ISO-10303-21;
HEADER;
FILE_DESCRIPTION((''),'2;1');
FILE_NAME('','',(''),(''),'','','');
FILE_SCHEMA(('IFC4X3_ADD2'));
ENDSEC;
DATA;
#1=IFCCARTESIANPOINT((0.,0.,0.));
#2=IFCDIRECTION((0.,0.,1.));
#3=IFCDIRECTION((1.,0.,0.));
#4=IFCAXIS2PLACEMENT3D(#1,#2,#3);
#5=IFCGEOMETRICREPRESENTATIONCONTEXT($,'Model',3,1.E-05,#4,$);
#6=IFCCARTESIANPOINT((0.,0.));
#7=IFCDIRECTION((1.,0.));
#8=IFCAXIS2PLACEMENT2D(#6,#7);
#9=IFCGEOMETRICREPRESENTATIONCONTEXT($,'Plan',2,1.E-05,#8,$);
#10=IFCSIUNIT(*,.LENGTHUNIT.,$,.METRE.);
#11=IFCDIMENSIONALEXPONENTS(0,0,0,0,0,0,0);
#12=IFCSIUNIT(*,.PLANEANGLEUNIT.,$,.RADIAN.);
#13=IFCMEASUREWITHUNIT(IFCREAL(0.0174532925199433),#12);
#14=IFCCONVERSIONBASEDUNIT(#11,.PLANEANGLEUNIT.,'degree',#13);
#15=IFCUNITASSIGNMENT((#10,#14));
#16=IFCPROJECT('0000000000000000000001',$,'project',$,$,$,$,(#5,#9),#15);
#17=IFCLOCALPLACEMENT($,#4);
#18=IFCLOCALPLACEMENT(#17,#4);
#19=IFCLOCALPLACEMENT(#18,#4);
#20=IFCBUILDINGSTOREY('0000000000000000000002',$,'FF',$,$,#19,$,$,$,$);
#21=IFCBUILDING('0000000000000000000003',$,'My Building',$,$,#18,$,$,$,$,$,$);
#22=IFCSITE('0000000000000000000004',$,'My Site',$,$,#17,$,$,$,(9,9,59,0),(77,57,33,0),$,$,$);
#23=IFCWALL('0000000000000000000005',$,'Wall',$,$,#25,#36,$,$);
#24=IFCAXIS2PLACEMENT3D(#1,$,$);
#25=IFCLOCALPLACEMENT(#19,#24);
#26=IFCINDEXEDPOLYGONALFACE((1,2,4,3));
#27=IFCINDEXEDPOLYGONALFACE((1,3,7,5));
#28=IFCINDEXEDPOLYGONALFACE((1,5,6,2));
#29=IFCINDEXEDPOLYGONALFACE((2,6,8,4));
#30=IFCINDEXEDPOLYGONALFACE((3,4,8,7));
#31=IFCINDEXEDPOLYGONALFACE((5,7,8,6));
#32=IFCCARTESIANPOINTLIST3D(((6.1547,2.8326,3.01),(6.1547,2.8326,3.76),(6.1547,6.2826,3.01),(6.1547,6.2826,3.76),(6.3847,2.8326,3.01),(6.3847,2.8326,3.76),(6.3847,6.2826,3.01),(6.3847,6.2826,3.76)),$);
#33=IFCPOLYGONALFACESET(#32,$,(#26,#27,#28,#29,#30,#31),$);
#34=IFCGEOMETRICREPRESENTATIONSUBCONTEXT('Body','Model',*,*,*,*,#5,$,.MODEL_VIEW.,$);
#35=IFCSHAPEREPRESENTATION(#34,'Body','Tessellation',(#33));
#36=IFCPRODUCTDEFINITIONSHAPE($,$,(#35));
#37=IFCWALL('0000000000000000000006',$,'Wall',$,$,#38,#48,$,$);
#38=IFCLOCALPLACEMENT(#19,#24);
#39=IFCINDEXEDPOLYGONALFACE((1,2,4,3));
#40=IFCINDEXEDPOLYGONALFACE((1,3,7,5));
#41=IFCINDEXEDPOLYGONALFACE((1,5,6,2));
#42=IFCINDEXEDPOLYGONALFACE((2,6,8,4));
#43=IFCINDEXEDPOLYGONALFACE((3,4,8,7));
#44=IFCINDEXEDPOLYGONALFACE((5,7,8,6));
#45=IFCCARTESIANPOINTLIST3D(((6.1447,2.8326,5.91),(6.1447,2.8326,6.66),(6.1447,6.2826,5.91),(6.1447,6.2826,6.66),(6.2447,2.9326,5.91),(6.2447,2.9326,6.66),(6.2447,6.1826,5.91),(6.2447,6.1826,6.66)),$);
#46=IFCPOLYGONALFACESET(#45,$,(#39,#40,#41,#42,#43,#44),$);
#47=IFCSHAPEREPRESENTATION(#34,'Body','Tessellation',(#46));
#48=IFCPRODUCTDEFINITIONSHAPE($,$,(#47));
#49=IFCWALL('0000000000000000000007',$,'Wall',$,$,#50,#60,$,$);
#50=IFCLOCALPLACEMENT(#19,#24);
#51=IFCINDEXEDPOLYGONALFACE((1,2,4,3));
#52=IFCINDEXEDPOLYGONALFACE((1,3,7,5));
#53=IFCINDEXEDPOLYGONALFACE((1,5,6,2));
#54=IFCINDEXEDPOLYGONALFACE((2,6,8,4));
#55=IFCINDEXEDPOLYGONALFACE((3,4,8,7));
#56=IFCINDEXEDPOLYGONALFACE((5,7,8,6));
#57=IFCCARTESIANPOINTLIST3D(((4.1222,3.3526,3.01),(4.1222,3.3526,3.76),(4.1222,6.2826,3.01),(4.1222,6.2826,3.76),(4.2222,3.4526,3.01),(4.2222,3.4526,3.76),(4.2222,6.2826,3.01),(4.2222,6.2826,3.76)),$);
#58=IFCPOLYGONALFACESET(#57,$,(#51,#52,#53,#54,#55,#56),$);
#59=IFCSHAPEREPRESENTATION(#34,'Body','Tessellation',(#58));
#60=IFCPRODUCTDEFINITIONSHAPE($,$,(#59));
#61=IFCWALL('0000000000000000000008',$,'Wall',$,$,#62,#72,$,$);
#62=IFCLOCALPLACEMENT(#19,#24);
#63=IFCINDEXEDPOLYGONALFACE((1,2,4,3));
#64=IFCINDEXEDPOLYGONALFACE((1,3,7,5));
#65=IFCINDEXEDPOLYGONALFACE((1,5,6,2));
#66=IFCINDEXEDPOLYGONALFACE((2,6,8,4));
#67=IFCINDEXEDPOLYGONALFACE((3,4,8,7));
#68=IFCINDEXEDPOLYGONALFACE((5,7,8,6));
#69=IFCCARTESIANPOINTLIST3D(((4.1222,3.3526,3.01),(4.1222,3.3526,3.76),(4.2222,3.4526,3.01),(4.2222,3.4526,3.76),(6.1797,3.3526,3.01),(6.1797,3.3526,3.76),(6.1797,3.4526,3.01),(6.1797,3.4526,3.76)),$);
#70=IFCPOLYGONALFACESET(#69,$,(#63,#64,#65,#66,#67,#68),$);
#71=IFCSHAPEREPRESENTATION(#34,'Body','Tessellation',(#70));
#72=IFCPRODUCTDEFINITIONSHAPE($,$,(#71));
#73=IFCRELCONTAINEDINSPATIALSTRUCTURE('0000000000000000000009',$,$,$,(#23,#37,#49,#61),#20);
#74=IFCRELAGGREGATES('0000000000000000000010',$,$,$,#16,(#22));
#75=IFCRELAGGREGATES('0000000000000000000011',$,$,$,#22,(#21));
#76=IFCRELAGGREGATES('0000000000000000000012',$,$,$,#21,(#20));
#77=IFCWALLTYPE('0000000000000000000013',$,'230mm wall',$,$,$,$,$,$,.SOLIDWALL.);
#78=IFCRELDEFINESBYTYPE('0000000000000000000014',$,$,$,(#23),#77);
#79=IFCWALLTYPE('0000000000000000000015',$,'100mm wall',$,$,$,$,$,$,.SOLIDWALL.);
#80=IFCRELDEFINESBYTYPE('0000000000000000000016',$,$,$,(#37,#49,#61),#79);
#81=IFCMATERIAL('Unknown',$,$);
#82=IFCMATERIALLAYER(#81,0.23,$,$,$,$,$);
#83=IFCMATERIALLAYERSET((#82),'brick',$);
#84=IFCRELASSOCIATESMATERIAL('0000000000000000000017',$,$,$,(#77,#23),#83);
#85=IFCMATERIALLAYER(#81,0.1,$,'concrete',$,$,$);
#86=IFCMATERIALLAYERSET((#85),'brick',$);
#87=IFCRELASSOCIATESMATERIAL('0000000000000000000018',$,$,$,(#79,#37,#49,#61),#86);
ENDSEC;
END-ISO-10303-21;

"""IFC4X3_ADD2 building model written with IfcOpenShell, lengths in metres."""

from ifc_helpers import new_model, entity, si_unit, converted_unit, frame, origin_with_axes, origin_2d_with_axis, place, context, subcontext, project, spatial, line, indexed_curve, outline, extrude, material, layer, layer_set, layer_usage, type_object, element, save


model = new_model("IFC4X3_ADD2")

# Units and contexts
model_context = context("Model", 3, precision=1e-05, world=origin_with_axes())
plan_context = context("Plan", 2, precision=1e-05, world=origin_2d_with_axis())
body_context_1 = subcontext(model_context, "Body", "Model", "MODEL_VIEW")
ifc_project = project(units=[si_unit("LENGTHUNIT", "METRE"), converted_unit("PLANEANGLEUNIT", "degree", entity("IfcReal", 0.0174532925199433), si_unit("PLANEANGLEUNIT", "RADIAN"), dimensions=[0, 0, 0, 0, 0, 0, 0])], contexts=[model_context, plan_context])

# Site, building, storey
site_placement = place(None, origin_with_axes())
site = spatial("IfcSite", under=ifc_project, at=site_placement, Name="My Site", RefLatitude=(9, 9, 59, 0), RefLongitude=(77, 57, 33, 0))
building_placement = place(site_placement, origin_with_axes())
building = spatial("IfcBuilding", under=site, at=building_placement, Name="My Building")
storey_placement = place(building_placement, origin_with_axes())
storey = spatial("IfcBuildingStorey", under=building, at=storey_placement, Name="FF")

# Shared definitions
ifc_material_1 = material(Name="Unknown")

# Shared definitions
ifc_layer_1 = layer(ifc_material_1, 0.23)
ifc_layer_set_1 = layer_set([ifc_layer_1], Name="brick")
wall_type_1 = type_object("IfcWallType", Name="230mm wall", PredefinedType="SOLIDWALL", material=ifc_layer_set_1)

# Walls
ifc_layer_usage_1 = layer_usage(ifc_layer_set_1, "AXIS2", "POSITIVE", 0.0)
wall_1_placement = place(storey_placement, frame((6.3847, 2.8326, 3.01), z_axis=(0.0, 0.0, 1.0), x_axis=(0.0, 1.0, 0.0)))
element("IfcWall", 1, at=wall_1_placement, inside=storey, type_object=wall_type_1, material=ifc_layer_usage_1, Name="Wall", context=body_context_1, shape_type="SweptSolid", body=[
    extrude(outline(indexed_curve([(0.0, 0.0), (0.0, 0.23), (3.45, 0.23), (3.45, 0.0)], segments=[line(1, 2, 3, 4, 1)])), origin_with_axes(), (0.0, 0.0, 1.0), 0.75),
])
ifc_layer_2 = layer(ifc_material_1, 0.1, Name="concrete")
ifc_layer_set_2 = layer_set([ifc_layer_2], Name="brick")
ifc_layer_usage_2 = layer_usage(ifc_layer_set_2, "AXIS2", "POSITIVE", 0.0)
wall_type_2 = type_object("IfcWallType", Name="100mm wall", PredefinedType="SOLIDWALL", material=ifc_layer_set_2)
wall_2_placement = place(storey_placement, frame((6.2447, 2.9326, 5.91), z_axis=(0.0, 0.0, 1.0), x_axis=(0.0, 1.0, 0.0)))
element("IfcWall", 2, at=wall_2_placement, inside=storey, type_object=wall_type_2, material=ifc_layer_usage_2, Name="Wall", context=body_context_1, shape_type="SweptSolid", body=[
    extrude(outline(indexed_curve([(0.0, 0.0), (-0.1, 0.1), (3.35, 0.1), (3.25, 0.0)], segments=[line(1, 2, 3, 4, 1)])), origin_with_axes(), (0.0, 0.0, 1.0), 0.75),
])
ifc_layer_usage_3 = layer_usage(ifc_layer_set_2, "AXIS2", "POSITIVE", 0.0)
wall_3_placement = place(storey_placement, frame((4.2222, 3.4526, 3.01), z_axis=(0.0, 0.0, 1.0), x_axis=(0.0, 1.0, 0.0)))
element("IfcWall", 3, at=wall_3_placement, inside=storey, type_object=wall_type_2, material=ifc_layer_usage_3, Name="Wall", context=body_context_1, shape_type="SweptSolid", body=[
    extrude(outline(indexed_curve([(0.0, 0.0), (-0.1, 0.1), (2.83, 0.1), (2.83, 0.0)], segments=[line(1, 2, 3, 4, 1)])), origin_with_axes(), (0.0, 0.0, 1.0), 0.75),
])
ifc_layer_usage_4 = layer_usage(ifc_layer_set_2, "AXIS2", "POSITIVE", 0.0)
wall_4_placement = place(storey_placement, frame((6.1797, 3.4526, 3.01), z_axis=(0.0, 0.0, 1.0), x_axis=(-1.0, 0.0, 0.0)))
element("IfcWall", 4, at=wall_4_placement, inside=storey, type_object=wall_type_2, material=ifc_layer_usage_4, Name="Wall", context=body_context_1, shape_type="SweptSolid", body=[
    extrude(outline(indexed_curve([(0.0, 0.0), (0.0, 0.1), (2.0575, 0.1), (1.9575, 0.0)], segments=[line(1, 2, 3, 4, 1)])), origin_with_axes(), (0.0, 0.0, 1.0), 0.75),
])

save(model, "model.ifc")
